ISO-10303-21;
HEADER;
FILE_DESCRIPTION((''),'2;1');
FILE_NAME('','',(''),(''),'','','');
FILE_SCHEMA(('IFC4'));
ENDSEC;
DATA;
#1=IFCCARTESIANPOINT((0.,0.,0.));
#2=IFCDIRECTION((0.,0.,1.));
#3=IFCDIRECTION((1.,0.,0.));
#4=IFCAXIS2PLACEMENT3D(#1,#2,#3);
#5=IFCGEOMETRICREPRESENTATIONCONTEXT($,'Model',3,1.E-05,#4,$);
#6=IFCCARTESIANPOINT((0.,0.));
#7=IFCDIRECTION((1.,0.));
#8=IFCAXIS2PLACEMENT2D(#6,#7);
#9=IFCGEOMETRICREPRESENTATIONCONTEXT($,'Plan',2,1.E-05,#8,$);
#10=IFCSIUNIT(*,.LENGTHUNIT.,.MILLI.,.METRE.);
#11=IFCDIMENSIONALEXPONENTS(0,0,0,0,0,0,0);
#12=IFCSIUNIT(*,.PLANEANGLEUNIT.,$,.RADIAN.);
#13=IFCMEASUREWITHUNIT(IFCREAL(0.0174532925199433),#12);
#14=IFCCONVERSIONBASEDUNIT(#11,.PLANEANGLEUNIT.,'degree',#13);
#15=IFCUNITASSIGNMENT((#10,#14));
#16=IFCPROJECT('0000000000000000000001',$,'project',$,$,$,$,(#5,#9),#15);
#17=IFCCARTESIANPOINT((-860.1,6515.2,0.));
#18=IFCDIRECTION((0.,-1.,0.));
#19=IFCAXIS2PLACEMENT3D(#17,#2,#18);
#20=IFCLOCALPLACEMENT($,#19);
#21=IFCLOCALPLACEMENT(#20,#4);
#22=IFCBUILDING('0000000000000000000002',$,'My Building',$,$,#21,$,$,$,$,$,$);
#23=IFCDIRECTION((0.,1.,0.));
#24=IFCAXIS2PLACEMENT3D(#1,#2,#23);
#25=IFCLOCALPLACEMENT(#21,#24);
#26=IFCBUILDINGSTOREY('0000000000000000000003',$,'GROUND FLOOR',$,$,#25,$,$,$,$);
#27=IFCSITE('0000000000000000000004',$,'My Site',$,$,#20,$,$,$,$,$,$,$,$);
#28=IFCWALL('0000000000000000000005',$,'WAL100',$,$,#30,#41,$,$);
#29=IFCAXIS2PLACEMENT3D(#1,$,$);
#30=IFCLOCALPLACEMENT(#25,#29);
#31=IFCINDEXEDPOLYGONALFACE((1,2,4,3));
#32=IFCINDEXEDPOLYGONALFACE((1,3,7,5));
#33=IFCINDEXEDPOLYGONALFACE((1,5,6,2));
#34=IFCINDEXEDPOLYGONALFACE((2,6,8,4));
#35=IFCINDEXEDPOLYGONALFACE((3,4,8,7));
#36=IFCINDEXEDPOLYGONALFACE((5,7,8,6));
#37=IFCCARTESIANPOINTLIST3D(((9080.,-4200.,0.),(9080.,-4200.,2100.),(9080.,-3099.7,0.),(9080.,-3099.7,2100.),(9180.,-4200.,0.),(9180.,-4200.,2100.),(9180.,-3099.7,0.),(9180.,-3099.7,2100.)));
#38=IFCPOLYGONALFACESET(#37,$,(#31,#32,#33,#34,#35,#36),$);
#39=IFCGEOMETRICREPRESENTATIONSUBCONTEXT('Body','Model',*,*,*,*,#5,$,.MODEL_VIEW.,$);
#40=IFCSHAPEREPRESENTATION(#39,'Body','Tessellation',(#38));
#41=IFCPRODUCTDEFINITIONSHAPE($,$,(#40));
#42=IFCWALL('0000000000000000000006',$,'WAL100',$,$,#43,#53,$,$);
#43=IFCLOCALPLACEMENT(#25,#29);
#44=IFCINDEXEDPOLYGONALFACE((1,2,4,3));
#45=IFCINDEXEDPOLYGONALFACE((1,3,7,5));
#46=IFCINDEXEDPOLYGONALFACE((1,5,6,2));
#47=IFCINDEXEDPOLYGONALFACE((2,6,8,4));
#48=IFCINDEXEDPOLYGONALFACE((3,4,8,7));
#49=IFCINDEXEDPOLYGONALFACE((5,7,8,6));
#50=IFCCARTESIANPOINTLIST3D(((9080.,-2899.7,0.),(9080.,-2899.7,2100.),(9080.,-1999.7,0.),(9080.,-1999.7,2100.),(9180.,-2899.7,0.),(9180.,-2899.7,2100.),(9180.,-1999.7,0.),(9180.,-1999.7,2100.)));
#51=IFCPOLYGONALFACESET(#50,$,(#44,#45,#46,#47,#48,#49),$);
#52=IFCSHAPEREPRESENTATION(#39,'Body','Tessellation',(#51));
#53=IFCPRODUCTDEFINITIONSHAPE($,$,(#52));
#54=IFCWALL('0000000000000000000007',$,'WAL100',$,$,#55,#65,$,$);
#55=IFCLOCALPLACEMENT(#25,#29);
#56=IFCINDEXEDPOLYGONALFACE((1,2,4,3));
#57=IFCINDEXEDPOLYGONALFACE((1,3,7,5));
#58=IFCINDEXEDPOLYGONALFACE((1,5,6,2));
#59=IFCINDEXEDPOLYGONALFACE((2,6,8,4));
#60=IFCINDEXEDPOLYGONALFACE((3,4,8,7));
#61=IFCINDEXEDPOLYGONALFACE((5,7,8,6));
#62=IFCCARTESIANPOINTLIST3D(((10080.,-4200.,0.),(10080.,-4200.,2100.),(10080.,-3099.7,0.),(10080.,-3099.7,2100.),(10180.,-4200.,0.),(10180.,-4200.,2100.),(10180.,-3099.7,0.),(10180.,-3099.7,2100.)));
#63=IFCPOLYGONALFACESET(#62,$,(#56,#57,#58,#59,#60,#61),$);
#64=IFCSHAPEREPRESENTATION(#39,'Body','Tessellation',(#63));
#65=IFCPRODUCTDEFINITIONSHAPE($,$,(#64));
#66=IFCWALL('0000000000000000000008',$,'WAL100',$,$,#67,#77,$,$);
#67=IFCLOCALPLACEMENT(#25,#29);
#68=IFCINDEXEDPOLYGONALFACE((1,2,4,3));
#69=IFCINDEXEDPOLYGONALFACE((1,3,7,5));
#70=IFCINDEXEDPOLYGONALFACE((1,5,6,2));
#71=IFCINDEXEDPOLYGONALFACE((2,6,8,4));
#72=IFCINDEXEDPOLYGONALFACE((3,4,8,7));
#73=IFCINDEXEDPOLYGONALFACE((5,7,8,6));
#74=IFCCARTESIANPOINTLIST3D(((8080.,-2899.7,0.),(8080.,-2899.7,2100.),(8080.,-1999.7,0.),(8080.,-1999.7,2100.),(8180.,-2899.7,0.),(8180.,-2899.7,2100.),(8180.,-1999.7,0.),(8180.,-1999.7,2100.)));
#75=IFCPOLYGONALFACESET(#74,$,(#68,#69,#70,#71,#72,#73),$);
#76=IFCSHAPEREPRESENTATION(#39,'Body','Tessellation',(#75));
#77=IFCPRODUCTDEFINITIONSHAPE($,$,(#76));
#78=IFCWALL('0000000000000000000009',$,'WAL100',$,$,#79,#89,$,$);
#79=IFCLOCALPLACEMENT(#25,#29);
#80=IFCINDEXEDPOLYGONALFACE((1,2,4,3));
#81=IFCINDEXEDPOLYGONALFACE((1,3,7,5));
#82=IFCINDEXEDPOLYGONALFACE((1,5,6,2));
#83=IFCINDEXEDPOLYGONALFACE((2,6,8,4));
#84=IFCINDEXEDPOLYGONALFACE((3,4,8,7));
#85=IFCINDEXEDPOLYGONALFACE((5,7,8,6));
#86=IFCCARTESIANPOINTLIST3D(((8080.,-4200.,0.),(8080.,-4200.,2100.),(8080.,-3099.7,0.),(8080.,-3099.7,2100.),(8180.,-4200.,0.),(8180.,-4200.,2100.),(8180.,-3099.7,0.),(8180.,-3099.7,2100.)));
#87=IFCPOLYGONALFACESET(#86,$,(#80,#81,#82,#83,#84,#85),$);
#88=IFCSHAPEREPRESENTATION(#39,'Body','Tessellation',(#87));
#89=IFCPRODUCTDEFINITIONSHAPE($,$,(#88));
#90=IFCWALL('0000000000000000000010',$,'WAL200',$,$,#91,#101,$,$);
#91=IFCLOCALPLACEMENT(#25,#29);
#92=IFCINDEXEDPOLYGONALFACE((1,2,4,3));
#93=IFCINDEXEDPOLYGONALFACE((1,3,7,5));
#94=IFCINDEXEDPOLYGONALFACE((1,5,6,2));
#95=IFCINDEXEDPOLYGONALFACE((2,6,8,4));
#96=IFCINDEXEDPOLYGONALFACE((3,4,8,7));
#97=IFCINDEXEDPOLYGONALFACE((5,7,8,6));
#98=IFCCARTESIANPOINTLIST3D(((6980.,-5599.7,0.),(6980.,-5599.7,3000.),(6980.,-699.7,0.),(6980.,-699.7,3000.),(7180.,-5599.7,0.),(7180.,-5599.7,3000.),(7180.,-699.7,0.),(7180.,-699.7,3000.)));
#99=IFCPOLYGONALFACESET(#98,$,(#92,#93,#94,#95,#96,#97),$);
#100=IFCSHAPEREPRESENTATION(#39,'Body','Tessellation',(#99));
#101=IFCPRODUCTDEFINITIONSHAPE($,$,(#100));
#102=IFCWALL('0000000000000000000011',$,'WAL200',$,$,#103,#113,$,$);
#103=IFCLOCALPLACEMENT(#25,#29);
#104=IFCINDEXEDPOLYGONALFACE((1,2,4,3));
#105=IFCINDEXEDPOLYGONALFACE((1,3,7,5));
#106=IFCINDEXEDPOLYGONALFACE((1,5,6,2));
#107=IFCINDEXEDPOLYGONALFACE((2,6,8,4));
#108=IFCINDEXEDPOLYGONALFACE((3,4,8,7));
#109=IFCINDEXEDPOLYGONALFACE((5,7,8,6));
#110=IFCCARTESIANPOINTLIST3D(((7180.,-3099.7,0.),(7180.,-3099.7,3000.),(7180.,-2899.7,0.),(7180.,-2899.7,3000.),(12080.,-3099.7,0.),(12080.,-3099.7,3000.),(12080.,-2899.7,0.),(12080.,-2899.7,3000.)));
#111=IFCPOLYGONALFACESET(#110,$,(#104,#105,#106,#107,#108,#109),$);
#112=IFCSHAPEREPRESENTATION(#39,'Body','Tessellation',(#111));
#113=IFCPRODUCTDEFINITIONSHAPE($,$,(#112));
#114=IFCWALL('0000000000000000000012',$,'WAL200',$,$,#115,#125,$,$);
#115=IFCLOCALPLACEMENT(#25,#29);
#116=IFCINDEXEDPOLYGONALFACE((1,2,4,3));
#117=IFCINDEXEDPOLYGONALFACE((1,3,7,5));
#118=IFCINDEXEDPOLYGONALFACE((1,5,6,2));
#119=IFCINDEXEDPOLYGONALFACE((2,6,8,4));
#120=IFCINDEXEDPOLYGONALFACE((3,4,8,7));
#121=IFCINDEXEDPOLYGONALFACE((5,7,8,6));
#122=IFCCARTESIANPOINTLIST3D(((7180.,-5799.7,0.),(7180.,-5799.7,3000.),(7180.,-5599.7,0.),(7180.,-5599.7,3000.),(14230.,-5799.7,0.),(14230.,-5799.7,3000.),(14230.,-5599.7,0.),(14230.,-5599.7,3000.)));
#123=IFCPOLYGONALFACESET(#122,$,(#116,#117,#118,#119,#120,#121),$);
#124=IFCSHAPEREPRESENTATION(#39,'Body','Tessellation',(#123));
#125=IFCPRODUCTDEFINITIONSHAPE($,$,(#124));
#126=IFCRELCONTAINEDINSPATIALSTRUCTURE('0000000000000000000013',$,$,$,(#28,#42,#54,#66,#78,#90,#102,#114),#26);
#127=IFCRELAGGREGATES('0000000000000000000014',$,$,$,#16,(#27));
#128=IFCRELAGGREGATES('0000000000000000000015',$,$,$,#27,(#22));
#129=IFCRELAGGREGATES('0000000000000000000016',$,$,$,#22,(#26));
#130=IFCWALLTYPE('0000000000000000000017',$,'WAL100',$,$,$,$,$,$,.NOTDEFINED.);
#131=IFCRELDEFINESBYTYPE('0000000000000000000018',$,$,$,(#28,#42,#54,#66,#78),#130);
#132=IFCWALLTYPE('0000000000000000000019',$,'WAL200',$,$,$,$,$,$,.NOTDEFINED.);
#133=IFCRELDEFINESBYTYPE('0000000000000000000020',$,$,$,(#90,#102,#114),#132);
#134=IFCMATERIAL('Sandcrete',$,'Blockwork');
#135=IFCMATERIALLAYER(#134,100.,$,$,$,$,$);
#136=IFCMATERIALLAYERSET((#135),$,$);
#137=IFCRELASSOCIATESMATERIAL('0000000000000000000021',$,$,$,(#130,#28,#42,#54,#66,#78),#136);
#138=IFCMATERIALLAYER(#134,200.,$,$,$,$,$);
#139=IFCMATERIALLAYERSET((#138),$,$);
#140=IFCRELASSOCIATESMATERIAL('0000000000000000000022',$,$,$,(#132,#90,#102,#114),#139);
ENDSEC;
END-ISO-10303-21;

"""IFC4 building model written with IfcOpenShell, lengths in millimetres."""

from ifc_helpers import new_model, entity, si_unit, converted_unit, frame, origin_with_axes, origin_2d_with_axis, place, context, subcontext, project, spatial, indexed_curve, outline, extrude, material, layer, layer_set, layer_usage, type_object, element, save


model = new_model("IFC4")

# Units and contexts
model_context = context("Model", 3, precision=1e-05, world=origin_with_axes())
plan_context = context("Plan", 2, precision=1e-05, world=origin_2d_with_axis())
body_context_1 = subcontext(model_context, "Body", "Model", "MODEL_VIEW")
ifc_project = project(units=[si_unit("LENGTHUNIT", "METRE", prefix="MILLI"), converted_unit("PLANEANGLEUNIT", "degree", entity("IfcReal", 0.0174532925199433), si_unit("PLANEANGLEUNIT", "RADIAN"), dimensions=[0, 0, 0, 0, 0, 0, 0])], contexts=[model_context, plan_context])

# Site, building, storey
site_placement = place(None, frame((-860.1, 6515.2, 0.0), z_axis=(0.0, 0.0, 1.0), x_axis=(0.0, -1.0, 0.0)))
site = spatial("IfcSite", under=ifc_project, at=site_placement, Name="My Site")
building_placement = place(site_placement, frame((0.0, 0.0, 0.0), z_axis=(0.0, 0.0, 1.0), x_axis=(1.0, 0.0, 0.0)))
building = spatial("IfcBuilding", under=site, at=building_placement, Name="My Building")
storey_placement = place(building_placement, frame((0.0, 0.0, 0.0), z_axis=(0.0, 0.0, 1.0), x_axis=(0.0, 1.0, 0.0)))
storey = spatial("IfcBuildingStorey", under=building, at=storey_placement, Name="GROUND FLOOR")

# Walls
ifc_material = material(Name="Sandcrete", Category="Blockwork")
ifc_layer_1 = layer(ifc_material, 100.0)
ifc_layer_set_1 = layer_set([ifc_layer_1])
ifc_layer_usage_1 = layer_usage(ifc_layer_set_1, "AXIS2", "POSITIVE", 0.0)
wall_type_1 = type_object("IfcWallType", Name="WAL100", PredefinedType="NOTDEFINED", material=ifc_layer_set_1)
wall_1_placement = place(storey_placement, frame((9080.0, -3099.7, 0.0), z_axis=(0.0, 0.0, 1.0), x_axis=(-0.000001, -1.0, 0.0)))
element("IfcWall", 1, at=wall_1_placement, inside=storey, type_object=wall_type_1, material=ifc_layer_usage_1, Name="WAL100", context=body_context_1, shape_type="SweptSolid", body=[
    extrude(outline(indexed_curve([(0.0, 0.0), (0.0, 100.0), (1100.3, 100.0), (1100.3, 0.0), (0.0, 0.0)], self_intersect=False)), origin_with_axes(), (0.0, 0.0, 1.0), 2100.0),
])
ifc_layer_usage_2 = layer_usage(ifc_layer_set_1, "AXIS2", "POSITIVE", 0.0)
wall_2_placement = place(storey_placement, frame((9080.0, -1999.7, 0.0), z_axis=(0.0, 0.0, 1.0), x_axis=(-0.000001, -1.0, 0.0)))
element("IfcWall", 2, at=wall_2_placement, inside=storey, type_object=wall_type_1, material=ifc_layer_usage_2, Name="WAL100", context=body_context_1, shape_type="SweptSolid", body=[
    extrude(outline(indexed_curve([(0.0, 0.0), (0.0, 100.0), (900.0, 100.0), (900.0, 0.0), (0.0, 0.0)], self_intersect=False)), origin_with_axes(), (0.0, 0.0, 1.0), 2100.0),
])
ifc_layer_usage_3 = layer_usage(ifc_layer_set_1, "AXIS2", "POSITIVE", 0.0)
wall_3_placement = place(storey_placement, frame((10080.0, -3099.7, 0.0), z_axis=(0.0, 0.0, 1.0), x_axis=(-0.000001, -1.0, 0.0)))
element("IfcWall", 3, at=wall_3_placement, inside=storey, type_object=wall_type_1, material=ifc_layer_usage_3, Name="WAL100", context=body_context_1, shape_type="SweptSolid", body=[
    extrude(outline(indexed_curve([(0.0, 0.0), (0.0, 100.0), (1100.3, 100.0), (1100.3, 0.0), (0.0, 0.0)], self_intersect=False)), origin_with_axes(), (0.0, 0.0, 1.0), 2100.0),
])
ifc_layer_usage_4 = layer_usage(ifc_layer_set_1, "AXIS2", "POSITIVE", 0.0)
wall_4_placement = place(storey_placement, frame((8080.0, -1999.7, 0.0), z_axis=(0.0, 0.0, 1.0), x_axis=(-0.000001, -1.0, 0.0)))
element("IfcWall", 4, at=wall_4_placement, inside=storey, type_object=wall_type_1, material=ifc_layer_usage_4, Name="WAL100", context=body_context_1, shape_type="SweptSolid", body=[
    extrude(outline(indexed_curve([(0.0, 0.0), (0.0, 100.0), (900.0, 100.0), (900.0, 0.0), (0.0, 0.0)], self_intersect=False)), origin_with_axes(), (0.0, 0.0, 1.0), 2100.0),
])
ifc_layer_usage_5 = layer_usage(ifc_layer_set_1, "AXIS2", "POSITIVE", 0.0)
wall_5_placement = place(storey_placement, frame((8080.0, -3099.7, 0.0), z_axis=(0.0, 0.0, 1.0), x_axis=(-0.000001, -1.0, 0.0)))
element("IfcWall", 5, at=wall_5_placement, inside=storey, type_object=wall_type_1, material=ifc_layer_usage_5, Name="WAL100", context=body_context_1, shape_type="SweptSolid", body=[
    extrude(outline(indexed_curve([(0.0, 0.0), (0.0, 100.0), (1100.3, 100.0), (1100.3, 0.0), (0.0, 0.0)], self_intersect=False)), origin_with_axes(), (0.0, 0.0, 1.0), 2100.0),
])
ifc_layer_2 = layer(ifc_material, 200.0)
ifc_layer_set_2 = layer_set([ifc_layer_2])
ifc_layer_usage_6 = layer_usage(ifc_layer_set_2, "AXIS2", "POSITIVE", 0.0)
wall_type_2 = type_object("IfcWallType", Name="WAL200", PredefinedType="NOTDEFINED", material=ifc_layer_set_2)
wall_6_placement = place(storey_placement, frame((7180.0, -5599.7, 0.0), z_axis=(0.0, 0.0, 1.0), x_axis=(0.000001, 1.0, 0.0)))
element("IfcWall", 6, at=wall_6_placement, inside=storey, type_object=wall_type_2, material=ifc_layer_usage_6, Name="WAL200", context=body_context_1, shape_type="SweptSolid", body=[
    extrude(outline(indexed_curve([(0.0, 0.0), (0.0, 200.0), (4900.0, 200.0), (4900.0, 0.0), (0.0, 0.0)], self_intersect=False)), origin_with_axes(), (0.0, 0.0, 1.0), 3000.0),
])
ifc_layer_usage_7 = layer_usage(ifc_layer_set_2, "AXIS2", "POSITIVE", 0.0)
wall_7_placement = place(storey_placement, frame((7180.0, -3099.7, 0.0), z_axis=(0.0, 0.0, 1.0), x_axis=(1.0, 0.0, 0.0)))
element("IfcWall", 7, at=wall_7_placement, inside=storey, type_object=wall_type_2, material=ifc_layer_usage_7, Name="WAL200", context=body_context_1, shape_type="SweptSolid", body=[
    extrude(outline(indexed_curve([(0.0, 0.0), (0.0, 200.0), (4900.0, 200.0), (4900.0, 0.0), (0.0, 0.0)], self_intersect=False)), origin_with_axes(), (0.0, 0.0, 1.0), 3000.0),
])
ifc_layer_usage_8 = layer_usage(ifc_layer_set_2, "AXIS2", "POSITIVE", 0.0)
wall_8_placement = place(storey_placement, frame((7180.0, -5799.7, 0.0), z_axis=(0.0, 0.0, 1.0), x_axis=(1.0, 0.0, 0.0)))
element("IfcWall", 8, at=wall_8_placement, inside=storey, type_object=wall_type_2, material=ifc_layer_usage_8, Name="WAL200", context=body_context_1, shape_type="SweptSolid", body=[
    extrude(outline(indexed_curve([(0.0, 0.0), (0.0, 200.0), (7050.0, 200.0), (7050.0, 0.0), (0.0, 0.0)], self_intersect=False)), origin_with_axes(), (0.0, 0.0, 1.0), 3000.0),
])

save(model, "model.ifc")
